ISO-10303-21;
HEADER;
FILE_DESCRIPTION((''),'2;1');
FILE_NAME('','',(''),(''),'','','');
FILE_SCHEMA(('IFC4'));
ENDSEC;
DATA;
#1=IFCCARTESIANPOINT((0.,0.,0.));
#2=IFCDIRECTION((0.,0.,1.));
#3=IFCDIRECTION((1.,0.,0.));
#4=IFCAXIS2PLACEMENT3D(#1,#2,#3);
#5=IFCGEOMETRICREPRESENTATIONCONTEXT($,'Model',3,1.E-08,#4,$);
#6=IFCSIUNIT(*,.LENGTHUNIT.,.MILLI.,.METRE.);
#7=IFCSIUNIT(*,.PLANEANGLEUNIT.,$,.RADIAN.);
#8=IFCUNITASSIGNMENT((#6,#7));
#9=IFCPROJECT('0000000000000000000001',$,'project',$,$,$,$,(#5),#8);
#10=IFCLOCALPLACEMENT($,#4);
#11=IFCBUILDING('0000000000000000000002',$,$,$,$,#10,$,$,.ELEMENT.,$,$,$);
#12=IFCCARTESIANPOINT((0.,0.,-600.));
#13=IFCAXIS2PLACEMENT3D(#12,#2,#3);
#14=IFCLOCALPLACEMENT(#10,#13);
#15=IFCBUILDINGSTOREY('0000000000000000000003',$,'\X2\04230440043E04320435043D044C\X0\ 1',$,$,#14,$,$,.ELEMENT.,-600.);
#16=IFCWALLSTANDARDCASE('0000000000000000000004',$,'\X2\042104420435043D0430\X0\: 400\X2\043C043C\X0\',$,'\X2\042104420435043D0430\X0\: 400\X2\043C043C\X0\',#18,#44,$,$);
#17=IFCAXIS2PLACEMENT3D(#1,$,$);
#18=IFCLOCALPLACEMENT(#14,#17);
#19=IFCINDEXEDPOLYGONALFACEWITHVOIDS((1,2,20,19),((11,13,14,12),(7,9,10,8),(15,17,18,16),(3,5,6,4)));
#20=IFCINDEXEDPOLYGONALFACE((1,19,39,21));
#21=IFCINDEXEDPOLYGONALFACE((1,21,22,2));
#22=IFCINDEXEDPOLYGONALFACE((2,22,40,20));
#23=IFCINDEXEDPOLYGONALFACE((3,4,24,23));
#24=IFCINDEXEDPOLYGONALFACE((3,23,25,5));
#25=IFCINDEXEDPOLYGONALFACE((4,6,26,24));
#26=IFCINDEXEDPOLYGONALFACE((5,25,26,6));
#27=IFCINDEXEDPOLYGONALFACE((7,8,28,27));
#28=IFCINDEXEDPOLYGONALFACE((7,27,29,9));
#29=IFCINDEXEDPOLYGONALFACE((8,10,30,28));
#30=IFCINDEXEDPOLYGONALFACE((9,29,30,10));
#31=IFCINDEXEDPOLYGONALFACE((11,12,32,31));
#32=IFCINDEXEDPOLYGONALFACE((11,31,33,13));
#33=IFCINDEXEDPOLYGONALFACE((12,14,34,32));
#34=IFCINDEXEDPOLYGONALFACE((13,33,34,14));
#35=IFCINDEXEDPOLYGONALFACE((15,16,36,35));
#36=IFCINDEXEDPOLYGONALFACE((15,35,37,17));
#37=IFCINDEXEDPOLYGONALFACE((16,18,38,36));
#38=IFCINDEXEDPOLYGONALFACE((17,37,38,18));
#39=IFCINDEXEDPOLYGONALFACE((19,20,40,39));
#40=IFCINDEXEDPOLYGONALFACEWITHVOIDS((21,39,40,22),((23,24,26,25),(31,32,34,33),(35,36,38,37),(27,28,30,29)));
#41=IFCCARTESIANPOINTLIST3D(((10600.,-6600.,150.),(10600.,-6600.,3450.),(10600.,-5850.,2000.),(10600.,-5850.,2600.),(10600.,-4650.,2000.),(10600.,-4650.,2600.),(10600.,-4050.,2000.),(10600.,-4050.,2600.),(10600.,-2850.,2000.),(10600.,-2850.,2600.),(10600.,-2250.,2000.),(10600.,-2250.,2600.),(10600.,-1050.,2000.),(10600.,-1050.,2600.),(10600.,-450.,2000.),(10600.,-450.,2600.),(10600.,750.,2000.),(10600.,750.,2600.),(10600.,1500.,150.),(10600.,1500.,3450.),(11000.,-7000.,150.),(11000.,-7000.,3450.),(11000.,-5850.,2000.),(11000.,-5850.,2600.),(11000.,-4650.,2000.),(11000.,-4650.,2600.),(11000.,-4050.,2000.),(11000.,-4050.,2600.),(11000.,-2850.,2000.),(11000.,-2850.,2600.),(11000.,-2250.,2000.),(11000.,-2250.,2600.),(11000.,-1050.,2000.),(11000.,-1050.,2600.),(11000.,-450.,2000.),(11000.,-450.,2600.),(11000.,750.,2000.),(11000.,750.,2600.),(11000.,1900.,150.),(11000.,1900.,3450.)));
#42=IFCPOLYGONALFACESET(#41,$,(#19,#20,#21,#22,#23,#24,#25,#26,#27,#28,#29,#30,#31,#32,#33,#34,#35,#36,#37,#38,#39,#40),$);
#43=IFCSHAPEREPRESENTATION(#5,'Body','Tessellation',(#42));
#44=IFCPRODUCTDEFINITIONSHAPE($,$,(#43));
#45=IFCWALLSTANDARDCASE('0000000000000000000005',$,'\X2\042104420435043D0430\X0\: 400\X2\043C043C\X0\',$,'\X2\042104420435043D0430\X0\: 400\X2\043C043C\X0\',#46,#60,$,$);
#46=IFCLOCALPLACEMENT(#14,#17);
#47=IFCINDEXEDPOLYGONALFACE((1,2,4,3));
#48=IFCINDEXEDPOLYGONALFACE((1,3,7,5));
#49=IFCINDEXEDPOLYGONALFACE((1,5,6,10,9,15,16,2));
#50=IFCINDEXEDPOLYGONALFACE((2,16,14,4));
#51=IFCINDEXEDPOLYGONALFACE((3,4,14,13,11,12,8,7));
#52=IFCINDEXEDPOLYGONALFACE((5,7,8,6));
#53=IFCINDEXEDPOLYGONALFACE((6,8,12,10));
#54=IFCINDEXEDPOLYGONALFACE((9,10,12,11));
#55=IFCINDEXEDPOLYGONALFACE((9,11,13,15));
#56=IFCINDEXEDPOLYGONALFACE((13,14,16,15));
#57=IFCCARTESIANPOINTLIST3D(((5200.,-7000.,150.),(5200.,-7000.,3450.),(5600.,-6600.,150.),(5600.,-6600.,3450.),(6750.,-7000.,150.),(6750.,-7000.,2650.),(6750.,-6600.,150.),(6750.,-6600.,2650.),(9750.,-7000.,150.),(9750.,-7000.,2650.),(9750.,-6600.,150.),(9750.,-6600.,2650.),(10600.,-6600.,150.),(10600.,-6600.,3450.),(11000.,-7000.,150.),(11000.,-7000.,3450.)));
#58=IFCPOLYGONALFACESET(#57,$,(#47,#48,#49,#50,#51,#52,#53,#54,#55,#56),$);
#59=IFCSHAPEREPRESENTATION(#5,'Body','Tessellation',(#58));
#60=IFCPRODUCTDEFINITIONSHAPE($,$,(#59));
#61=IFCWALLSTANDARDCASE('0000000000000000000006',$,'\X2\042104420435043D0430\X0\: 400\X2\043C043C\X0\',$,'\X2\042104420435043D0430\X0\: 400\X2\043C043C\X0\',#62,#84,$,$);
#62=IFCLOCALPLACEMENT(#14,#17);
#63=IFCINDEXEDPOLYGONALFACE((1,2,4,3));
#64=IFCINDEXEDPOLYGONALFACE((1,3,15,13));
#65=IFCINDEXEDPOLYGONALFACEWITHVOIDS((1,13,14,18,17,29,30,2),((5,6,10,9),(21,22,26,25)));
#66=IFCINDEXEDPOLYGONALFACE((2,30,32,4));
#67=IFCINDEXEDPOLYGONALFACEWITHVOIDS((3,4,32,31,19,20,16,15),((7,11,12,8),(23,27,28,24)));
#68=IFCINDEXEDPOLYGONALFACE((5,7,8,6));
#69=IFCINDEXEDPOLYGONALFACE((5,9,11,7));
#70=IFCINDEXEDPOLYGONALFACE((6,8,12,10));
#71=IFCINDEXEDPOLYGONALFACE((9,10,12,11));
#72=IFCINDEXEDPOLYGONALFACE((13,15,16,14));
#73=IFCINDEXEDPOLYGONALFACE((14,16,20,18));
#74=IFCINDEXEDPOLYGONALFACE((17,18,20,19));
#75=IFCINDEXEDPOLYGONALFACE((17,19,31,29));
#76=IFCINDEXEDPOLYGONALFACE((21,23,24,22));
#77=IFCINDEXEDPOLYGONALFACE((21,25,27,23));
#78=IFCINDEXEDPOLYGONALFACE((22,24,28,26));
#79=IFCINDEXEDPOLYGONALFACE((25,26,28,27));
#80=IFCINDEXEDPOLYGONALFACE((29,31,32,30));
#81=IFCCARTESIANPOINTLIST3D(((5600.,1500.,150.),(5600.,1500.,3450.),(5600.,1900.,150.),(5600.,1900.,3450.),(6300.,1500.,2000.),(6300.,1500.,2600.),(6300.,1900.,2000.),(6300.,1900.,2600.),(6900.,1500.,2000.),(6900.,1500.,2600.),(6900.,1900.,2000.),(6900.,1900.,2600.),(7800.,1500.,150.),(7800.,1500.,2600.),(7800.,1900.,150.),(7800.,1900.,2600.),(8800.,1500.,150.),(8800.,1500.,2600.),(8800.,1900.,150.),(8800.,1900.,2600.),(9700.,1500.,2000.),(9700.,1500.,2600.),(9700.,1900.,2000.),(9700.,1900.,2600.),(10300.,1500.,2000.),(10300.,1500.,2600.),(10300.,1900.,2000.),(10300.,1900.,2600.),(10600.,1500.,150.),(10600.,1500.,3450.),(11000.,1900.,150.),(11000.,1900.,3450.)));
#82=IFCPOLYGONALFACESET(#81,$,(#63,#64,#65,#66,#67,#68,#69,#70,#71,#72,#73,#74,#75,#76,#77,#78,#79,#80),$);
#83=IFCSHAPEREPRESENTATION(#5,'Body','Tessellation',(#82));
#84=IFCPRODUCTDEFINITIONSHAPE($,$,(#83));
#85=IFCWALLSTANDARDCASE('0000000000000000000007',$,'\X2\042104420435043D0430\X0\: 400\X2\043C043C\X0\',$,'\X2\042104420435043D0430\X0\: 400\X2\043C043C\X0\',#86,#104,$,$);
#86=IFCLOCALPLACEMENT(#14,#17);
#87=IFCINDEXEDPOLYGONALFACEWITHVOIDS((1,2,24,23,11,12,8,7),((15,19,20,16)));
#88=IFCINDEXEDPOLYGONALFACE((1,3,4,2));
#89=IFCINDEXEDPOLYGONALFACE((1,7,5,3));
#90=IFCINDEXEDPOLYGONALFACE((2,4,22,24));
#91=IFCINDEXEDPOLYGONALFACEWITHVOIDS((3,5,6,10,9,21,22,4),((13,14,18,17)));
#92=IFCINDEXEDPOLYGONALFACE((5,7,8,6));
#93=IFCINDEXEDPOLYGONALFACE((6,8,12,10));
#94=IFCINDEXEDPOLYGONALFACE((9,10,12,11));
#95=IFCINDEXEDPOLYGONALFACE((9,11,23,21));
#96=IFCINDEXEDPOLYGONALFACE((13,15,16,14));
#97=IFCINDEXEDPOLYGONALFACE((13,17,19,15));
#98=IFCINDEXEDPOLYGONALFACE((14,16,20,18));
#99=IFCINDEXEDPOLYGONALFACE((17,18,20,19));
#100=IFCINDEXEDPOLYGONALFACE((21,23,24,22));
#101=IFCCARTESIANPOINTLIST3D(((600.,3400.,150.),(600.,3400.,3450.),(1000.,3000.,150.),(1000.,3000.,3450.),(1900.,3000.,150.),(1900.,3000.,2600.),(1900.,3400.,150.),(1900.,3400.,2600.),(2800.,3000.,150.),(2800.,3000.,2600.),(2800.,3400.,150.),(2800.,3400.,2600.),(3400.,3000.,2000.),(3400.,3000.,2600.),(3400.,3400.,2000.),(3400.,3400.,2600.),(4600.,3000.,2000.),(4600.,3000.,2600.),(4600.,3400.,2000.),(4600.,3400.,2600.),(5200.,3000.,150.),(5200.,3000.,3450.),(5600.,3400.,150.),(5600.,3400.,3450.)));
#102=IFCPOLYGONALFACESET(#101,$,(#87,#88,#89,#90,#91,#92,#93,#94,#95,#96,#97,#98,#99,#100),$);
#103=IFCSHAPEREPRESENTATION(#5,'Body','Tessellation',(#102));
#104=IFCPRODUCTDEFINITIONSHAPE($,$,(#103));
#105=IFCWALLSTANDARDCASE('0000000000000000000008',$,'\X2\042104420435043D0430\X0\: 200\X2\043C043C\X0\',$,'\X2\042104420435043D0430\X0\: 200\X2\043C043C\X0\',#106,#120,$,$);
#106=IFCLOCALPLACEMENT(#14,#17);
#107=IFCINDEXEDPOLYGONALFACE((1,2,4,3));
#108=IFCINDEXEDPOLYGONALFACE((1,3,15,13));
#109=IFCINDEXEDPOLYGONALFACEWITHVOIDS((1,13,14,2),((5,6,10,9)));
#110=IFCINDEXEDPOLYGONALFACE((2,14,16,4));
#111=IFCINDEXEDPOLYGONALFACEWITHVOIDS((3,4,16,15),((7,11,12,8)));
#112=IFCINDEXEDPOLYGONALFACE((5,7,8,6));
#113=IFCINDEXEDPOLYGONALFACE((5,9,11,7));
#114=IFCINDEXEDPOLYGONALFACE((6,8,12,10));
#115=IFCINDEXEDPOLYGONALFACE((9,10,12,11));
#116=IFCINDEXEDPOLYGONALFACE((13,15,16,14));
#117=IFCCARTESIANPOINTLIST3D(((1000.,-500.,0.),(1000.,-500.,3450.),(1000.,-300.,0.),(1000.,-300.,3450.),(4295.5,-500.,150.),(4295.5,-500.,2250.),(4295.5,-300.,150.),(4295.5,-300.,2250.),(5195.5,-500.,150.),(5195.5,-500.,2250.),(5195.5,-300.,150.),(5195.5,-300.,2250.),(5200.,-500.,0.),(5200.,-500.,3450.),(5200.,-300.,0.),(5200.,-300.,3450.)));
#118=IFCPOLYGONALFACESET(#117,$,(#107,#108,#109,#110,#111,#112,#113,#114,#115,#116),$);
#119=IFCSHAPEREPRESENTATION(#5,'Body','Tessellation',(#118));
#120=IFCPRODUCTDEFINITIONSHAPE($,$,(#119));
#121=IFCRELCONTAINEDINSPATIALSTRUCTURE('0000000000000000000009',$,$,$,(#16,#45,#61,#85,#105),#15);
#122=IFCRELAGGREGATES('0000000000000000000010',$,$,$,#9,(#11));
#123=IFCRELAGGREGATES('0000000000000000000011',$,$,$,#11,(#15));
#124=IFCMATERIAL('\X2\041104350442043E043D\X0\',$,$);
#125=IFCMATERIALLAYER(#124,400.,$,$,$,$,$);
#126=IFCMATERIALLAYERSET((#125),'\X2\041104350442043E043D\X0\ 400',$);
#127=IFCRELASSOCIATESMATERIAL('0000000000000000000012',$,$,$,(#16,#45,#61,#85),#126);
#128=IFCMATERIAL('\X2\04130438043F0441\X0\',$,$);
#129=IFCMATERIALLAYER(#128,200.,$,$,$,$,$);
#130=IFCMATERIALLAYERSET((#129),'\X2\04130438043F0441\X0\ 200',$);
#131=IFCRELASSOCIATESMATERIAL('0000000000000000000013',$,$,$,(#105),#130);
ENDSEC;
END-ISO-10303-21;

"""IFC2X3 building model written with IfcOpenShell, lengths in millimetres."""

from ifc_helpers import new_model, si_unit, frame, frame_2d, origin_with_axes, place, context, project, spatial, polyline, segment, composite_curve, rectangle, outline, extrude, material, layer, layer_set, layer_usage, element, save


model = new_model("IFC2X3")

# Units and contexts
model_context = context("Model", 3, precision=1e-08, world=origin_with_axes())
ifc_project = project(units=[si_unit("LENGTHUNIT", "METRE", prefix="MILLI"), si_unit("PLANEANGLEUNIT", "RADIAN")], contexts=[model_context])

# Building, storey
building_placement = place(None, origin_with_axes())
building = spatial("IfcBuilding", under=ifc_project, at=building_placement, CompositionType="ELEMENT")
storey_placement = place(building_placement, frame((0.0, 0.0, -600.0), z_axis=(0.0, 0.0, 1.0), x_axis=(1.0, 0.0, 0.0)))
storey = spatial("IfcBuildingStorey", under=building, at=storey_placement, Name="Уровень 1", CompositionType="ELEMENT", Elevation=-600.0)

# Shared definitions
ifc_material_1 = material(Name="Бетон")

# Wall, openings
ifc_layer_1 = layer(ifc_material_1, 400.0)
ifc_layer_set_1 = layer_set([ifc_layer_1], Name="Бетон 400")
ifc_layer_usage_1 = layer_usage(ifc_layer_set_1, "AXIS2", "NEGATIVE", 0.0)
wall_1_placement = place(storey_placement, frame((11000.0, 1900.0, 150.0), z_axis=(0.0, 0.0, 1.0), x_axis=(0.0, -1.0, 0.0)))
wall_1 = element("IfcWallStandardCase", 1, at=wall_1_placement, inside=storey, material=ifc_layer_usage_1, Name="Стена: 400мм", ObjectType="Стена: 400мм", context=model_context, shape_type="SweptSolid", body=[
    extrude(outline(composite_curve([segment(polyline([(400.0, -400.0), (8500.0, -400.0)]), True, "CONTINUOUS"), segment(polyline([(8500.0, -400.0), (8900.0, 0.0)]), True, "CONTINUOUS"), segment(polyline([(8900.0, 0.0), (0.0, 0.0)]), True, "CONTINUOUS"), segment(polyline([(0.0, 0.0), (400.0, -400.0)]), True, "CONTINUOUS")], self_intersect=False)), origin_with_axes(), (0.0, 0.0, 1.0), 3300.0),
])
opening_1_placement = place(wall_1_placement, frame((7750.0, 0.0, 1850.0), z_axis=(0.0, 0.0, 1.0), x_axis=(-1.0, 0.0, 0.0)))
element("IfcOpeningElement", 2, at=opening_1_placement, cuts=wall_1, ObjectType="Opening", context=model_context, shape_type="SweptSolid", body=[
    extrude(rectangle(XDim=1200.0, YDim=600.0, at=frame_2d((600.0, 300.0), x_axis=(1.0, 0.0))), frame((0.0, -5.0, 0.0), z_axis=(0.0, -1.0, 0.0), x_axis=(1.0, 0.0, 0.0)), (0.0, 0.0, -1.0), 410.0),
])
opening_2_placement = place(wall_1_placement, frame((5950.0, 0.0, 1850.0), z_axis=(0.0, 0.0, 1.0), x_axis=(-1.0, 0.0, 0.0)))
element("IfcOpeningElement", 3, at=opening_2_placement, cuts=wall_1, ObjectType="Opening", context=model_context, shape_type="SweptSolid", body=[
    extrude(rectangle(XDim=1200.0, YDim=600.0, at=frame_2d((600.0, 300.0), x_axis=(1.0, 0.0))), frame((0.0, -5.0, 0.0), z_axis=(0.0, -1.0, 0.0), x_axis=(1.0, 0.0, 0.0)), (0.0, 0.0, -1.0), 410.0),
])
opening_3_placement = place(wall_1_placement, frame((4150.0, 0.0, 1850.0), z_axis=(0.0, 0.0, 1.0), x_axis=(-1.0, 0.0, 0.0)))
element("IfcOpeningElement", 4, at=opening_3_placement, cuts=wall_1, ObjectType="Opening", context=model_context, shape_type="SweptSolid", body=[
    extrude(rectangle(XDim=1200.0, YDim=600.0, at=frame_2d((600.0, 300.0), x_axis=(1.0, 0.0))), frame((0.0, -5.0, 0.0), z_axis=(0.0, -1.0, 0.0), x_axis=(1.0, 0.0, 0.0)), (0.0, 0.0, -1.0), 410.0),
])
opening_4_placement = place(wall_1_placement, frame((2350.0, 0.0, 1850.0), z_axis=(0.0, 0.0, 1.0), x_axis=(-1.0, 0.0, 0.0)))
element("IfcOpeningElement", 5, at=opening_4_placement, cuts=wall_1, ObjectType="Opening", context=model_context, shape_type="SweptSolid", body=[
    extrude(rectangle(XDim=1200.0, YDim=600.0, at=frame_2d((600.0, 300.0), x_axis=(1.0, 0.0))), frame((0.0, -5.0, 0.0), z_axis=(0.0, -1.0, 0.0), x_axis=(1.0, 0.0, 0.0)), (0.0, 0.0, -1.0), 410.0),
])

# Wall, opening
ifc_layer_usage_2 = layer_usage(ifc_layer_set_1, "AXIS2", "NEGATIVE", 0.0)
wall_2_placement = place(storey_placement, frame((11000.0, -7000.0, 150.0), z_axis=(0.0, 0.0, 1.0), x_axis=(-1.0, 0.0, 0.0)))
wall_2 = element("IfcWallStandardCase", 6, at=wall_2_placement, inside=storey, material=ifc_layer_usage_2, Name="Стена: 400мм", ObjectType="Стена: 400мм", context=model_context, shape_type="SweptSolid", body=[
    extrude(outline(composite_curve([segment(polyline([(400.0, -400.0), (5400.0, -400.0)]), True, "CONTINUOUS"), segment(polyline([(5400.0, -400.0), (5800.0, 0.0)]), True, "CONTINUOUS"), segment(polyline([(5800.0, 0.0), (0.0, 0.0)]), True, "CONTINUOUS"), segment(polyline([(0.0, 0.0), (400.0, -400.0)]), True, "CONTINUOUS")], self_intersect=False)), origin_with_axes(), (0.0, 0.0, 1.0), 3300.0),
])
opening_5_placement = place(wall_2_placement, frame((4250.0, 0.0, 0.0), z_axis=(0.0, 0.0, 1.0), x_axis=(-1.0, 0.0, 0.0)))
element("IfcOpeningElement", 7, at=opening_5_placement, cuts=wall_2, ObjectType="Opening", context=model_context, shape_type="SweptSolid", body=[
    extrude(rectangle(XDim=3000.0, YDim=2500.0, at=frame_2d((1500.0, 1250.0), x_axis=(1.0, 0.0))), frame((0.0, -5.0, 0.0), z_axis=(0.0, -1.0, 0.0), x_axis=(1.0, 0.0, 0.0)), (0.0, 0.0, -1.0), 410.0),
])

# Wall, openings
ifc_layer_usage_3 = layer_usage(ifc_layer_set_1, "AXIS2", "NEGATIVE", 400.0)
wall_3_placement = place(storey_placement, frame((11000.0, 1900.0, 150.0), z_axis=(0.0, 0.0, 1.0), x_axis=(-1.0, 0.0, 0.0)))
wall_3 = element("IfcWallStandardCase", 8, at=wall_3_placement, inside=storey, material=ifc_layer_usage_3, Name="Стена: 400мм", ObjectType="Стена: 400мм", context=model_context, shape_type="SweptSolid", body=[
    extrude(outline(composite_curve([segment(polyline([(0.0, 0.0), (5400.0, 0.0)]), True, "CONTINUOUS"), segment(polyline([(5400.0, 0.0), (5400.0, 400.0)]), True, "CONTINUOUS"), segment(polyline([(5400.0, 400.0), (400.0, 400.0)]), True, "CONTINUOUS"), segment(polyline([(400.0, 400.0), (0.0, 0.0)]), True, "CONTINUOUS")], self_intersect=False)), origin_with_axes(), (0.0, 0.0, 1.0), 3300.0),
])
opening_6_placement = place(wall_3_placement, frame((2200.0, 0.0, 0.0), z_axis=(0.0, 0.0, 1.0), x_axis=(1.0, 0.0, 0.0)))
element("IfcOpeningElement", 9, at=opening_6_placement, cuts=wall_3, ObjectType="Opening", context=model_context, shape_type="SweptSolid", body=[
    extrude(rectangle(XDim=1000.0, YDim=2450.0, at=frame_2d((500.0, 1225.0), x_axis=(1.0, 0.0))), frame((0.0, -5.0, 0.0), z_axis=(0.0, -1.0, 0.0), x_axis=(1.0, 0.0, 0.0)), (0.0, 0.0, -1.0), 410.0),
])
opening_7_placement = place(wall_3_placement, frame((700.0, 0.0, 1850.0), z_axis=(0.0, 0.0, 1.0), x_axis=(1.0, 0.0, 0.0)))
element("IfcOpeningElement", 10, at=opening_7_placement, cuts=wall_3, ObjectType="Opening", context=model_context, shape_type="SweptSolid", body=[
    extrude(rectangle(XDim=600.0, YDim=600.0, at=frame_2d((300.0, 300.0), x_axis=(1.0, 0.0))), frame((0.0, -5.0, 0.0), z_axis=(0.0, -1.0, 0.0), x_axis=(1.0, 0.0, 0.0)), (0.0, 0.0, -1.0), 410.0),
])
opening_8_placement = place(wall_3_placement, frame((4100.0, 0.0, 1850.0), z_axis=(0.0, 0.0, 1.0), x_axis=(1.0, 0.0, 0.0)))
element("IfcOpeningElement", 11, at=opening_8_placement, cuts=wall_3, ObjectType="Opening", context=model_context, shape_type="SweptSolid", body=[
    extrude(rectangle(XDim=600.0, YDim=600.0, at=frame_2d((300.0, 300.0), x_axis=(1.0, 0.0))), frame((0.0, -5.0, 0.0), z_axis=(0.0, -1.0, 0.0), x_axis=(1.0, 0.0, 0.0)), (0.0, 0.0, -1.0), 410.0),
])

# Wall, openings
ifc_layer_usage_4 = layer_usage(ifc_layer_set_1, "AXIS2", "NEGATIVE", 400.0)
wall_4_placement = place(storey_placement, frame((5500.0, 3400.0, 150.0), z_axis=(0.0, 0.0, 1.0), x_axis=(-1.0, 0.0, 0.0)))
wall_4 = element("IfcWallStandardCase", 12, at=wall_4_placement, inside=storey, material=ifc_layer_usage_4, Name="Стена: 400мм", ObjectType="Стена: 400мм", context=model_context, shape_type="SweptSolid", body=[
    extrude(outline(composite_curve([segment(polyline([(-100.0, 0.0), (4900.0, 0.0)]), True, "CONTINUOUS"), segment(polyline([(4900.0, 0.0), (4500.0, 400.0)]), True, "CONTINUOUS"), segment(polyline([(4500.0, 400.0), (300.0, 400.0)]), True, "CONTINUOUS"), segment(polyline([(300.0, 400.0), (-100.0, 0.0)]), True, "CONTINUOUS")], self_intersect=False)), origin_with_axes(), (0.0, 0.0, 1.0), 3300.0),
])
opening_9_placement = place(wall_4_placement, frame((2700.0, 0.0, 0.0), z_axis=(0.0, 0.0, 1.0), x_axis=(1.0, 0.0, 0.0)))
element("IfcOpeningElement", 13, at=opening_9_placement, cuts=wall_4, ObjectType="Opening", context=model_context, shape_type="SweptSolid", body=[
    extrude(rectangle(XDim=900.0, YDim=2450.0, at=frame_2d((450.0, 1225.0), x_axis=(1.0, 0.0))), frame((0.0, -5.0, 0.0), z_axis=(0.0, -1.0, 0.0), x_axis=(1.0, 0.0, 0.0)), (0.0, 0.0, -1.0), 410.0),
])
opening_10_placement = place(wall_4_placement, frame((900.0, 0.0, 1850.0), z_axis=(0.0, 0.0, 1.0), x_axis=(1.0, 0.0, 0.0)))
element("IfcOpeningElement", 14, at=opening_10_placement, cuts=wall_4, ObjectType="Opening", context=model_context, shape_type="SweptSolid", body=[
    extrude(rectangle(XDim=1200.0, YDim=600.0, at=frame_2d((600.0, 300.0), x_axis=(1.0, 0.0))), frame((0.0, -5.0, 0.0), z_axis=(0.0, -1.0, 0.0), x_axis=(1.0, 0.0, 0.0)), (0.0, 0.0, -1.0), 410.0),
])

# Wall, opening
ifc_material_2 = material(Name="Гипс")
ifc_layer_2 = layer(ifc_material_2, 200.0)
ifc_layer_set_2 = layer_set([ifc_layer_2], Name="Гипс 200")
ifc_layer_usage_5 = layer_usage(ifc_layer_set_2, "AXIS2", "NEGATIVE", 0.0)
wall_5_placement = place(storey_placement, frame((5200.0, -500.0, 0.0), z_axis=(0.0, 0.0, 1.0), x_axis=(-1.0, 0.0, 0.0)))
wall_5 = element("IfcWallStandardCase", 15, at=wall_5_placement, inside=storey, material=ifc_layer_usage_5, Name="Стена: 200мм", ObjectType="Стена: 200мм", context=model_context, shape_type="SweptSolid", body=[
    extrude(outline(composite_curve([segment(polyline([(0.0, -200.0), (4200.0, -200.0)]), True, "CONTINUOUS"), segment(polyline([(4200.0, -200.0), (4200.0, 0.0)]), True, "CONTINUOUS"), segment(polyline([(4200.0, 0.0), (0.0, 0.0)]), True, "CONTINUOUS"), segment(polyline([(0.0, 0.0), (0.0, -200.0)]), True, "CONTINUOUS")], self_intersect=False)), origin_with_axes(), (0.0, 0.0, 1.0), 3450.0),
])
opening_11_placement = place(wall_5_placement, frame((904.5, 0.0, 150.0), z_axis=(0.0, 0.0, 1.0), x_axis=(-1.0, 0.0, 0.0)))
element("IfcOpeningElement", 16, at=opening_11_placement, cuts=wall_5, ObjectType="Opening", context=model_context, shape_type="SweptSolid", body=[
    extrude(rectangle(XDim=900.0, YDim=2100.0, at=frame_2d((450.0, 1050.0), x_axis=(1.0, 0.0))), frame((0.0, -5.0, 0.0), z_axis=(0.0, -1.0, 0.0), x_axis=(1.0, 0.0, 0.0)), (0.0, 0.0, -1.0), 210.0),
])

save(model, "model.ifc")
